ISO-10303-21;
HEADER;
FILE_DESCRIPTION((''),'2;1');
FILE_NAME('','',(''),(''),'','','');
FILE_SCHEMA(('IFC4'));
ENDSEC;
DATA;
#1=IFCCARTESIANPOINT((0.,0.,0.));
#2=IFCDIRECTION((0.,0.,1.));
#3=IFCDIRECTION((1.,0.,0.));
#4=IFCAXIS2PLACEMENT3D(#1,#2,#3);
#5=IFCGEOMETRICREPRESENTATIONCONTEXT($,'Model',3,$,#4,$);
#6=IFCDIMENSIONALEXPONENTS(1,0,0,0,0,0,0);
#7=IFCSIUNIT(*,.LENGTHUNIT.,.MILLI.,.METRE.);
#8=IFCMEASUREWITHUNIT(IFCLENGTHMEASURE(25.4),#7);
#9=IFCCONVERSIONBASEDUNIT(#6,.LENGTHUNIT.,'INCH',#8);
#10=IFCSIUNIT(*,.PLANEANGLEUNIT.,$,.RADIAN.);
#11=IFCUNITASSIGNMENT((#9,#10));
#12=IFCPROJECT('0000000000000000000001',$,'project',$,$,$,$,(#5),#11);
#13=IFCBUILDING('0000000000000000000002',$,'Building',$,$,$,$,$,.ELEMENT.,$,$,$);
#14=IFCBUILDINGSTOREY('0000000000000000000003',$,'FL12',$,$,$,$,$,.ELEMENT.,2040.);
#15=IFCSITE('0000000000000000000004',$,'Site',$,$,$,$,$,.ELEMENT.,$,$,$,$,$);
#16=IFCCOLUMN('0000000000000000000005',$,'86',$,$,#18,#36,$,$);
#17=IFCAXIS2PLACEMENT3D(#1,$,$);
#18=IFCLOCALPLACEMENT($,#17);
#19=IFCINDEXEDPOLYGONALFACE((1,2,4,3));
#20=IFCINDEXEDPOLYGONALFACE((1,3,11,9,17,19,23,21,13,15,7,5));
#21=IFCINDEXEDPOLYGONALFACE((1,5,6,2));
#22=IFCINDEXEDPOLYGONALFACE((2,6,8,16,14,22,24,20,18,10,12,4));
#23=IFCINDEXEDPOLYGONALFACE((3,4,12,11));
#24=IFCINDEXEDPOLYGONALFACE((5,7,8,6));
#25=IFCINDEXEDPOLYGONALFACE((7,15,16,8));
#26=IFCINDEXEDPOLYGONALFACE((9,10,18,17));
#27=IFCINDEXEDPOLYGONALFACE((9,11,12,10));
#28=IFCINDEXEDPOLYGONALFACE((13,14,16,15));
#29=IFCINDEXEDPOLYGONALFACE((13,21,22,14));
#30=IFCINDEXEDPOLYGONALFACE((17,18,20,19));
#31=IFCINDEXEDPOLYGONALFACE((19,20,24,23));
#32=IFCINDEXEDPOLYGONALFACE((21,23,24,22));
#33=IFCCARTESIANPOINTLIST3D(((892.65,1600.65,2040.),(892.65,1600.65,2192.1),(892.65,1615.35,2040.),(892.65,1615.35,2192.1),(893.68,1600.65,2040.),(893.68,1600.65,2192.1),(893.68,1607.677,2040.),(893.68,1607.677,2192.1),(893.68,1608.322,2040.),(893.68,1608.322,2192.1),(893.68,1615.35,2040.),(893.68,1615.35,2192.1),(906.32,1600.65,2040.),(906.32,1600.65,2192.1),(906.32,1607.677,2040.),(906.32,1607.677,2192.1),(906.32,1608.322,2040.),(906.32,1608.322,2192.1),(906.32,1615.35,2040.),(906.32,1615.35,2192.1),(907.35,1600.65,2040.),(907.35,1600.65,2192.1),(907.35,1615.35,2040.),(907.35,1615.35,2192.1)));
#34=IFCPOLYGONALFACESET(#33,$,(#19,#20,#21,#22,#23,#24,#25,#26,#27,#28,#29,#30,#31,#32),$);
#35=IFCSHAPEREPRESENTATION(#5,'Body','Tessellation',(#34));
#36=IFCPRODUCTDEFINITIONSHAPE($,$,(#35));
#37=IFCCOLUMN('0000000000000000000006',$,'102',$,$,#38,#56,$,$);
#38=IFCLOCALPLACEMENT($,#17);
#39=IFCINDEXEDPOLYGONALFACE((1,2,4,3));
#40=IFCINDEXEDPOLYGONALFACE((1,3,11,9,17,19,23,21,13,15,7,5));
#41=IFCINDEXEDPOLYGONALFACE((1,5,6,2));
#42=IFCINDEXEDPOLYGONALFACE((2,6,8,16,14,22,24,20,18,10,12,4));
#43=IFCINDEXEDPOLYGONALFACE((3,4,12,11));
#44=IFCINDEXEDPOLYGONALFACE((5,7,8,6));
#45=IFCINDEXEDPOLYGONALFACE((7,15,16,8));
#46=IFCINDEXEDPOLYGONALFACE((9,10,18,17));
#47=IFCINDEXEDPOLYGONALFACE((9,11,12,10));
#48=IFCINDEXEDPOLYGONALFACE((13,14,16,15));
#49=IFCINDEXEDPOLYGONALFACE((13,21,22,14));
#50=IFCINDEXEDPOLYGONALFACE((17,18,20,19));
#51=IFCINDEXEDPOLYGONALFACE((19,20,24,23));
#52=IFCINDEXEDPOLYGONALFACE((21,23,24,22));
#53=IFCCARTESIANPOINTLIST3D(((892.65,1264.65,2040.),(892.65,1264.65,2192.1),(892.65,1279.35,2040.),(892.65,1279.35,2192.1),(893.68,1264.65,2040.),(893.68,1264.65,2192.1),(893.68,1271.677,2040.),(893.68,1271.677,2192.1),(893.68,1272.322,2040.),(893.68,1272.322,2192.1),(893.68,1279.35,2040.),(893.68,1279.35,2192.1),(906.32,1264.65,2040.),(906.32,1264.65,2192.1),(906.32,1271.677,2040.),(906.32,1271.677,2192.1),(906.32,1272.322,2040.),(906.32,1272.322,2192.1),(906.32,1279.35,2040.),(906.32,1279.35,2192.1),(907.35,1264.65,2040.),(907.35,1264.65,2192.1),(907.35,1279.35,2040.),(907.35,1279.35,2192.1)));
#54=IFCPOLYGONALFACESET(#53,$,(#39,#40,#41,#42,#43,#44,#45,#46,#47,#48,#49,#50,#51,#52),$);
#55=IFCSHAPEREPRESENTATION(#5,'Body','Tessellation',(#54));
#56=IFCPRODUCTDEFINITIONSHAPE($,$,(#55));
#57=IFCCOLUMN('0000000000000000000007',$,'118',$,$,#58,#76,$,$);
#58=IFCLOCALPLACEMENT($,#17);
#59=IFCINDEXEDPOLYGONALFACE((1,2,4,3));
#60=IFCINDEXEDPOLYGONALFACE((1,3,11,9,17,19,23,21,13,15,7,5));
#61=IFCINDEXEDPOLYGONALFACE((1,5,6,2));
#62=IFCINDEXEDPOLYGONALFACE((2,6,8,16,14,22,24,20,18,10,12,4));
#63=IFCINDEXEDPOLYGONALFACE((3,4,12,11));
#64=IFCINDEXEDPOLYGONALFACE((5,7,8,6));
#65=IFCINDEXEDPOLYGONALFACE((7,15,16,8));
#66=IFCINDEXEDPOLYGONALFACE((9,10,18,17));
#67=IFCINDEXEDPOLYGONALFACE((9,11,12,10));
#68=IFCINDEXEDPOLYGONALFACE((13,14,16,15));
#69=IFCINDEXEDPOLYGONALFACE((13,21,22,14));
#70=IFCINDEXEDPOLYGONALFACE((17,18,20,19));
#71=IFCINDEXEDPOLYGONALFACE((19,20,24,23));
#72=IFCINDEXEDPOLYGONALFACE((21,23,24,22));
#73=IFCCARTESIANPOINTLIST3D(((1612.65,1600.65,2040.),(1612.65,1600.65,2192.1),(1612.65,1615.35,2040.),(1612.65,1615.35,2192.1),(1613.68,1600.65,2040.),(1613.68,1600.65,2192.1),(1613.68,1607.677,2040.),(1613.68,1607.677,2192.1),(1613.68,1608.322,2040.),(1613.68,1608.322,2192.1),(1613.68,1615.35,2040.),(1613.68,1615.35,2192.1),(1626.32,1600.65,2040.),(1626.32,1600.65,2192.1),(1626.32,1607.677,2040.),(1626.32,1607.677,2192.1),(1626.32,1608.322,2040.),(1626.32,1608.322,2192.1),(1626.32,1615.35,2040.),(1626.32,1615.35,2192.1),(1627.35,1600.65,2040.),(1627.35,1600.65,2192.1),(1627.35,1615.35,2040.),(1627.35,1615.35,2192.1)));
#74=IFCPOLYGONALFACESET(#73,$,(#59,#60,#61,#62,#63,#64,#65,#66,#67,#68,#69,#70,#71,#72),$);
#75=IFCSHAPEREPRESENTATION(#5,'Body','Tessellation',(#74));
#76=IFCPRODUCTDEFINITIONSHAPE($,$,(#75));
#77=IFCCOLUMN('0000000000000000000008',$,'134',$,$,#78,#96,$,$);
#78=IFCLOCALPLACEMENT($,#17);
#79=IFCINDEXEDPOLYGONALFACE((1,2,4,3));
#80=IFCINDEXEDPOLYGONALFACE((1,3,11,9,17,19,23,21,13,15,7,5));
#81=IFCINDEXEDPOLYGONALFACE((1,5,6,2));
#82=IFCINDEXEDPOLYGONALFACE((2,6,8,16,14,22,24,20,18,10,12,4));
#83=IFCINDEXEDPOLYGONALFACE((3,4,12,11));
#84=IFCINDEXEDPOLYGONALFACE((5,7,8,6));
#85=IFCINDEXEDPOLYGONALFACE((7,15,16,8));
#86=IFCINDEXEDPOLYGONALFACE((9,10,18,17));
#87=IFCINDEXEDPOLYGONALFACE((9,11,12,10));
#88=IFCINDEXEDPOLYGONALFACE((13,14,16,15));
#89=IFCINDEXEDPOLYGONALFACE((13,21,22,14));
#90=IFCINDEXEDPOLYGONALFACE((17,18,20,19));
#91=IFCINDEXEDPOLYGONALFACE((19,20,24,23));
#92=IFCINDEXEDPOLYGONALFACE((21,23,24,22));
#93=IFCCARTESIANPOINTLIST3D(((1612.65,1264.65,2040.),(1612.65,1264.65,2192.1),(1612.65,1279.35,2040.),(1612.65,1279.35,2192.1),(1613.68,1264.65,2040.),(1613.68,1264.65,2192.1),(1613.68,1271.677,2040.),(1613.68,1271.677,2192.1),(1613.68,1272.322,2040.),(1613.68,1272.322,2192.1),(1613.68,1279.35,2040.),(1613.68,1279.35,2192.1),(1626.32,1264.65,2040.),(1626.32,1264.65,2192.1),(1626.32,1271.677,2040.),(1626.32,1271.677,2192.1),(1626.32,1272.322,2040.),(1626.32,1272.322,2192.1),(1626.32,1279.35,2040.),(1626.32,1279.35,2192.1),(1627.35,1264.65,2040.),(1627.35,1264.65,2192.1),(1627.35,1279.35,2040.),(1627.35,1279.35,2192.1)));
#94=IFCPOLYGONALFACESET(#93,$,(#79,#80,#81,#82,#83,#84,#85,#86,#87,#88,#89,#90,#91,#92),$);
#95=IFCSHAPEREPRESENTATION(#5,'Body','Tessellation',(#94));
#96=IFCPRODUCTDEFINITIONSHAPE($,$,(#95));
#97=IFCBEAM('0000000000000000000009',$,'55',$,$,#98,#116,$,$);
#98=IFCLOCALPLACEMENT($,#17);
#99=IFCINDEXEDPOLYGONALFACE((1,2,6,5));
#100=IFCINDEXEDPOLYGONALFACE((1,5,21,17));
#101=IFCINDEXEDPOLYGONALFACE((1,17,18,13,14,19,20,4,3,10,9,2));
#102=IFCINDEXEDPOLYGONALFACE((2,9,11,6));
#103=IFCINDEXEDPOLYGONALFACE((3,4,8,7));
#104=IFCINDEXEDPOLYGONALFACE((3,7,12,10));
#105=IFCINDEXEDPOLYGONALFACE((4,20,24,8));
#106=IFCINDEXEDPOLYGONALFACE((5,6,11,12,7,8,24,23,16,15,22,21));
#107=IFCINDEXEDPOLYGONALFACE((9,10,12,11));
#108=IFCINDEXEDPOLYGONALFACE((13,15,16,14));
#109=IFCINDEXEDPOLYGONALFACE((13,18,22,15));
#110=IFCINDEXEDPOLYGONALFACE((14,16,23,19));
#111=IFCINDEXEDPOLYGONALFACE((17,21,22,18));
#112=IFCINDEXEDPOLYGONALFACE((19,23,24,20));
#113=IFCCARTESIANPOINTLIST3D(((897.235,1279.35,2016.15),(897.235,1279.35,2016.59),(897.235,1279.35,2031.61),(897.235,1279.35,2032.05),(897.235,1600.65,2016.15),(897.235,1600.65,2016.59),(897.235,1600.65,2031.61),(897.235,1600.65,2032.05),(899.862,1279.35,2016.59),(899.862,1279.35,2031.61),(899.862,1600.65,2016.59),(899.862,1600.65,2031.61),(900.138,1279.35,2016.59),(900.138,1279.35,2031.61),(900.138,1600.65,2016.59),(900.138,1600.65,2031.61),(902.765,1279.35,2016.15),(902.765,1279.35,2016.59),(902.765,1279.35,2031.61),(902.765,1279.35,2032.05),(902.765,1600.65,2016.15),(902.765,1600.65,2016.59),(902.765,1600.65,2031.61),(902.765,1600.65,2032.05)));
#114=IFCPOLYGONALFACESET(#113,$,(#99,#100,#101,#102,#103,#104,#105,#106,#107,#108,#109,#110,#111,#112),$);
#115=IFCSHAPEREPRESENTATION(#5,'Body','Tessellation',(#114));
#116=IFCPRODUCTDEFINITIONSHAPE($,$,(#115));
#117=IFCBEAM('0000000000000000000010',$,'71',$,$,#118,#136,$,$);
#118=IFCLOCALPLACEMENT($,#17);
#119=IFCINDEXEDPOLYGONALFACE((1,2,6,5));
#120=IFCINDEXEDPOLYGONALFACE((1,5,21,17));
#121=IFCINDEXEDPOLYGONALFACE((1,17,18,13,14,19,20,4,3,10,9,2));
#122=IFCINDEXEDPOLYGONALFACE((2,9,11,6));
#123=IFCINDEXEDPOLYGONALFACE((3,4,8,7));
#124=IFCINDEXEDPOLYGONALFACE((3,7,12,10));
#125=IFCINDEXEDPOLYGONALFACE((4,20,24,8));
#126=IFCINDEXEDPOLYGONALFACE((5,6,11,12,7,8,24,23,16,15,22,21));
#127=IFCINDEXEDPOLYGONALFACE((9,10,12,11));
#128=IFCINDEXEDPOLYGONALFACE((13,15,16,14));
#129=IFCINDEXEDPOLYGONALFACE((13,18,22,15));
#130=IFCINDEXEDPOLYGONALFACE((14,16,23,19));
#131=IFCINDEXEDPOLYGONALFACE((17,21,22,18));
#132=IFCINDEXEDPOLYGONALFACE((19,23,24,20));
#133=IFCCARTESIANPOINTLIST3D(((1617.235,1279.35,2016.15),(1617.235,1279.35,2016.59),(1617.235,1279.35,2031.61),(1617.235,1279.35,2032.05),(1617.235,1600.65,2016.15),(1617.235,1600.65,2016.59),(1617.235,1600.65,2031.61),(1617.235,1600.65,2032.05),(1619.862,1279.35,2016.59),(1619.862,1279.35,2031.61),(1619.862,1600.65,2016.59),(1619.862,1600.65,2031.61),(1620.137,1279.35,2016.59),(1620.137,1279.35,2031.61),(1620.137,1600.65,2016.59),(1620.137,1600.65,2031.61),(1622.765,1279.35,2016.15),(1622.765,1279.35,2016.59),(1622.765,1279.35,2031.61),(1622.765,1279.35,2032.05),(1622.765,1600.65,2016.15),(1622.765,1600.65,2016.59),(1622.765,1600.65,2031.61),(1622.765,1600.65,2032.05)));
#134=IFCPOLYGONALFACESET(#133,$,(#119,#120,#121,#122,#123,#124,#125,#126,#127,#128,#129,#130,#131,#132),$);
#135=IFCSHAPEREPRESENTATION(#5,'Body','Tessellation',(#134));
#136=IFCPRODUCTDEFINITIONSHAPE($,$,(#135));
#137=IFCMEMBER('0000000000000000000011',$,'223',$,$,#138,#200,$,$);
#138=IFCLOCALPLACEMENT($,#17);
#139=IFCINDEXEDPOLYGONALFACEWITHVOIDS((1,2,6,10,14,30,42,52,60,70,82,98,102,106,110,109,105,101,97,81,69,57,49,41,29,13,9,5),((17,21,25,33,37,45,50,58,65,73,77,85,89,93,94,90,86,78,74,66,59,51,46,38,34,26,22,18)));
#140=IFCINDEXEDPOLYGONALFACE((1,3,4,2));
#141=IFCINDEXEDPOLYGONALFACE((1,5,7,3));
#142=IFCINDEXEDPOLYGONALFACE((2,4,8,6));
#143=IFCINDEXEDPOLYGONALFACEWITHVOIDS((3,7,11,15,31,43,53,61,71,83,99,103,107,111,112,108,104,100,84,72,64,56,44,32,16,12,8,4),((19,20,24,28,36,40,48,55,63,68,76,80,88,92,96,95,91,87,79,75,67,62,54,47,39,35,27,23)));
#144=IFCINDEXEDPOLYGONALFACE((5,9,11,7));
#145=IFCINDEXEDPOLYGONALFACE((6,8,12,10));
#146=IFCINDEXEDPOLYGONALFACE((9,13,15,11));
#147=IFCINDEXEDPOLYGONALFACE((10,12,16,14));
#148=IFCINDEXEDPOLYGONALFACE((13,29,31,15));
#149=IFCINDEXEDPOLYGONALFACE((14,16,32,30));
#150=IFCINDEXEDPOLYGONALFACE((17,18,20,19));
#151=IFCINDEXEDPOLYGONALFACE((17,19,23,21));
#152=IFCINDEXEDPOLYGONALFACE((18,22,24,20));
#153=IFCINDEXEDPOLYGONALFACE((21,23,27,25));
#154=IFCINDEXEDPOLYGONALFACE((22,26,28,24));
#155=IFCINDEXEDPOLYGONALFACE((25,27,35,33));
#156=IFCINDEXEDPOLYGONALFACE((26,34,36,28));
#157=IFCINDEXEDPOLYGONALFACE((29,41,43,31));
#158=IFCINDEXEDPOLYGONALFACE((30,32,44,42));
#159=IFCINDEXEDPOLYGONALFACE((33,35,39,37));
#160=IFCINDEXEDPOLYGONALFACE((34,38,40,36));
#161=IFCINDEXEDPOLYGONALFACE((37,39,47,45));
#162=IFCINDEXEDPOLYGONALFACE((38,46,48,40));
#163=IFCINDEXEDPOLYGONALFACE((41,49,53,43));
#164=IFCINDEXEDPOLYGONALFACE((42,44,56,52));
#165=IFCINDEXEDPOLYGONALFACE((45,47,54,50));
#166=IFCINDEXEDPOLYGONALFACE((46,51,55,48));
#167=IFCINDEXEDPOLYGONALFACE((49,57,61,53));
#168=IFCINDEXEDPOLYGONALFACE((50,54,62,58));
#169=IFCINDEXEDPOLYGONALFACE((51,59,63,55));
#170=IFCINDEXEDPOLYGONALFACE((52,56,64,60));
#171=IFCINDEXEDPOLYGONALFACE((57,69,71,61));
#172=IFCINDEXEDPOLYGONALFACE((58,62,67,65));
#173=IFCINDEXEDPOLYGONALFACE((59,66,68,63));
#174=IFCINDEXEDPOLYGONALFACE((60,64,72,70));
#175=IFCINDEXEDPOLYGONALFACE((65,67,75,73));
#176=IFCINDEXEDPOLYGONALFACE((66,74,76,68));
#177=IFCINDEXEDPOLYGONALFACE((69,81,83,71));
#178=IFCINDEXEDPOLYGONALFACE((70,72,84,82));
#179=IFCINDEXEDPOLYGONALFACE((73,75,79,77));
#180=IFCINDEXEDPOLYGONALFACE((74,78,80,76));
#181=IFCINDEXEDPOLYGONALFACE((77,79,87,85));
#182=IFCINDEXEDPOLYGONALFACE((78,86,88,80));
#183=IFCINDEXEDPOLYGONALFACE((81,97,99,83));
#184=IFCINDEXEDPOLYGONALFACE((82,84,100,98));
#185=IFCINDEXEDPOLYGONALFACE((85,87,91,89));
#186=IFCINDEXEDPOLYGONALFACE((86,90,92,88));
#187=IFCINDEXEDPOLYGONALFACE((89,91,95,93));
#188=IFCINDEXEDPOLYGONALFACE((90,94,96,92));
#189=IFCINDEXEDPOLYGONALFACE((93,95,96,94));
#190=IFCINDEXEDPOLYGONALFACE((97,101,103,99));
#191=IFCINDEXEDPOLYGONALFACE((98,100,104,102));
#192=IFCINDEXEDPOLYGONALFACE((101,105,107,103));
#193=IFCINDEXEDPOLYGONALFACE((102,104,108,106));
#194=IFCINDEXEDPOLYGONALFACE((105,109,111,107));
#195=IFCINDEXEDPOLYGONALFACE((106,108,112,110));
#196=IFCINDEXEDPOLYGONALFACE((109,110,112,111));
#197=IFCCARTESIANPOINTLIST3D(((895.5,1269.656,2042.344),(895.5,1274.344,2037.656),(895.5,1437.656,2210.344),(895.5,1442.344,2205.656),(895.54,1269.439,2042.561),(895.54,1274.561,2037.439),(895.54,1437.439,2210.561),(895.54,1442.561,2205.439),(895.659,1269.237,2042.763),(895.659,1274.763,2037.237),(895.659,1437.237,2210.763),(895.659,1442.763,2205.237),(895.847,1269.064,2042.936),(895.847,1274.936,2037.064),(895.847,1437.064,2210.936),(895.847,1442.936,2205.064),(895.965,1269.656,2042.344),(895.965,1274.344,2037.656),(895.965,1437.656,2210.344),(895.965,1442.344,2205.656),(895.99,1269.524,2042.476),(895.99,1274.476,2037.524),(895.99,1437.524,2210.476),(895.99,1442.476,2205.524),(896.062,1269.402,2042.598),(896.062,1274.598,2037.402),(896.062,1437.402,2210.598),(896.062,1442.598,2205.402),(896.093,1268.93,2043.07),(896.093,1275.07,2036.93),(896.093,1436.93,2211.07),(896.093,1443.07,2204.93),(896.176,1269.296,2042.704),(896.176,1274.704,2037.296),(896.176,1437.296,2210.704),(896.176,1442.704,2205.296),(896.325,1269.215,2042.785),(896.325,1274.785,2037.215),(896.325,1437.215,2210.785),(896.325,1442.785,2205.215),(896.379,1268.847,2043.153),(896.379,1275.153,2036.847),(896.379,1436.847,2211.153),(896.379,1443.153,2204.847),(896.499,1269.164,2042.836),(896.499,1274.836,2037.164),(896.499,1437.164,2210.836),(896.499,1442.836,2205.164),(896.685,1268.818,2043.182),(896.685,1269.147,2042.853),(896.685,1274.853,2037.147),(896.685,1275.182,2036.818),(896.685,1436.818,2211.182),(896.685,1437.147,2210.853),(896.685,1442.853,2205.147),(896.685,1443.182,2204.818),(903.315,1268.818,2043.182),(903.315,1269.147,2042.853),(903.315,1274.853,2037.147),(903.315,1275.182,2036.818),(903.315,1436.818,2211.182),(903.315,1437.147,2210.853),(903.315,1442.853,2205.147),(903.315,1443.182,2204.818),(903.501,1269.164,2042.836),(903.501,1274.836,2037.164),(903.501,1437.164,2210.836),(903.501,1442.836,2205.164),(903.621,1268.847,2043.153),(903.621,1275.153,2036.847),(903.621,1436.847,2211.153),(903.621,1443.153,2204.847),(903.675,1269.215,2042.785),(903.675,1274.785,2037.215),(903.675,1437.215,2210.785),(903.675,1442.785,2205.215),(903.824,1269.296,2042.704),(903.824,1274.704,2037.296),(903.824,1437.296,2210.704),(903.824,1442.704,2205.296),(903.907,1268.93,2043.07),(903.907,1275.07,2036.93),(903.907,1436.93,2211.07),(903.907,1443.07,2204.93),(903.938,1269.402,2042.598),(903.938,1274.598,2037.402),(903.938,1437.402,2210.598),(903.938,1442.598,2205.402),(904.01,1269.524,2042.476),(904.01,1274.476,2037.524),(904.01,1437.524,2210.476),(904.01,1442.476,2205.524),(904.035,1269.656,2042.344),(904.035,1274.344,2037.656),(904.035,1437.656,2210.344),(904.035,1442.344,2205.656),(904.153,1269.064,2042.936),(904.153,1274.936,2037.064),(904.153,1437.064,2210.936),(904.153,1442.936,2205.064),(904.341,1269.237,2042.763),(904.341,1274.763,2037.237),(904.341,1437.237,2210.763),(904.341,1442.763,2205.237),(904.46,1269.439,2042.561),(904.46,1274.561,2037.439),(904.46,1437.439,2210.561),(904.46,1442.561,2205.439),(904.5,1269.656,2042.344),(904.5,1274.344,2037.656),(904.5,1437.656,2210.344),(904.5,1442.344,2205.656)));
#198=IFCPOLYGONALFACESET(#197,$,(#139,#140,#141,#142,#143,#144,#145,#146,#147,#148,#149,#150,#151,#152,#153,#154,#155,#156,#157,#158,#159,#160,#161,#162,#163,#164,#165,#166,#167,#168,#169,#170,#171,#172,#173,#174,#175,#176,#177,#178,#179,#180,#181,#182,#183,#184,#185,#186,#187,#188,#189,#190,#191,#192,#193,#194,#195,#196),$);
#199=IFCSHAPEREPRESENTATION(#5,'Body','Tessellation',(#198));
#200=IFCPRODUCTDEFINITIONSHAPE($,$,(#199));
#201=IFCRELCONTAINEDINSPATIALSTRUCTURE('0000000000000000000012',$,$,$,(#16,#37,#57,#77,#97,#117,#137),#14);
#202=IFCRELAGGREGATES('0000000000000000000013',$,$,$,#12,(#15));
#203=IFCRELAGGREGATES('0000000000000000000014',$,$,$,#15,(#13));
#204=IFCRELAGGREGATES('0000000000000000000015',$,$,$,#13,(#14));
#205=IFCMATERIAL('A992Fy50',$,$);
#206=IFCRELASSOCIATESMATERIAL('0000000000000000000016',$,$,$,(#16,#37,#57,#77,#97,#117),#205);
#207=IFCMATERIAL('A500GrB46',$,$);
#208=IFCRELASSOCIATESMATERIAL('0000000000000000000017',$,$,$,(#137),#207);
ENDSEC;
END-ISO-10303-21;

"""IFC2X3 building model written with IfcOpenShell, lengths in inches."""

from ifc_helpers import new_model, entity, si_unit, converted_unit, frame, origin_with_axes, origin_2d_with_axis, place, context, project, spatial, hollow_rectangle, i_section, transform_2d, derived_profile, extrude, material, element, save


model = new_model("IFC2X3")

# Units and contexts
model_context = context("Model", 3, world=origin_with_axes())
ifc_project = project(units=[converted_unit("LENGTHUNIT", "INCH", entity("IfcLengthMeasure", 25.4), si_unit("LENGTHUNIT", "METRE", prefix="MILLI"), dimensions=[1, 0, 0, 0, 0, 0, 0]), si_unit("PLANEANGLEUNIT", "RADIAN")], contexts=[model_context])

# Site, building, storey
site = spatial("IfcSite", under=ifc_project, Name="Site", CompositionType="ELEMENT")
building = spatial("IfcBuilding", under=site, Name="Building", CompositionType="ELEMENT")
storey = spatial("IfcBuildingStorey", under=building, Name="FL12", CompositionType="ELEMENT", Elevation=2040.0)

# Columns
ifc_material_1 = material(Name="A992Fy50")
for number, where, z_axis, x_axis, name in (
    (1, (900.0, 1608.0, 2040.0), (0.0, 0.0, 1.0), (0.0, -1.0, 0.0), "86"),
    (2, (900.0, 1272.0, 2040.0), (0.0, 0.0, 1.0), (0.0, -1.0, 0.0), "102"),
    (3, (1620.0, 1608.0, 2040.0), (0.0, 0.0, 1.0), (0.0, -1.0, 0.0), "118"),
    (4, (1620.0, 1272.0, 2040.0), (0.0, 0.0, 1.0), (0.0, -1.0, 0.0), "134"),
):
    element("IfcColumn", number, at=place(None, frame(where, z_axis=z_axis, x_axis=x_axis)), inside=storey, material=ifc_material_1, Name=name, context=model_context, shape_type="SweptSolid", body=[
        extrude(i_section(OverallWidth=14.7, OverallDepth=14.7, WebThickness=0.645, FlangeThickness=1.03, at=origin_2d_with_axis()), origin_with_axes(), (0.0, 0.0, 1.0), 152.1),
    ])

# Beams
for number, where, z_axis, x_axis, name in (
    (5, (900.0, 1279.35, 2040.0), (0.0, 1.0, 0.0), (-1.0, 0.0, 0.0), "55"),
    (6, (1620.0, 1279.35, 2040.0), (0.0, 1.0, 0.0), (-1.0, 0.0, 0.0), "71"),
):
    element("IfcBeam", number, at=place(None, frame(where, z_axis=z_axis, x_axis=x_axis)), inside=storey, material=ifc_material_1, Name=name, context=model_context, shape_type="SweptSolid", body=[
        extrude(derived_profile(i_section(OverallWidth=5.53, OverallDepth=15.9, WebThickness=0.275, FlangeThickness=0.44, at=origin_2d_with_axis()), transform_2d((0.0, -7.95))), origin_with_axes(), (0.0, 0.0, 1.0), 321.3),
    ])

# Member
ifc_material_2 = material(Name="A500GrB46")
for number, where, z_axis, x_axis, name in (
    (7, (900.0, 1272.0, 2040.0), (0.0, 0.707107, 0.707107), (-1.0, 0.0, 0.0), "223"),
):
    element("IfcMember", number, at=place(None, frame(where, z_axis=z_axis, x_axis=x_axis)), inside=storey, material=ifc_material_2, Name=name, context=model_context, shape_type="SweptSolid", body=[
        extrude(hollow_rectangle(XDim=9.0, YDim=9.0, WallThickness=0.465, InnerFilletRadius=0.72, OuterFilletRadius=1.185, at=origin_2d_with_axis()), origin_with_axes(), (0.0, 0.0, 1.0), 237.588),
    ])

save(model, "model.ifc")
